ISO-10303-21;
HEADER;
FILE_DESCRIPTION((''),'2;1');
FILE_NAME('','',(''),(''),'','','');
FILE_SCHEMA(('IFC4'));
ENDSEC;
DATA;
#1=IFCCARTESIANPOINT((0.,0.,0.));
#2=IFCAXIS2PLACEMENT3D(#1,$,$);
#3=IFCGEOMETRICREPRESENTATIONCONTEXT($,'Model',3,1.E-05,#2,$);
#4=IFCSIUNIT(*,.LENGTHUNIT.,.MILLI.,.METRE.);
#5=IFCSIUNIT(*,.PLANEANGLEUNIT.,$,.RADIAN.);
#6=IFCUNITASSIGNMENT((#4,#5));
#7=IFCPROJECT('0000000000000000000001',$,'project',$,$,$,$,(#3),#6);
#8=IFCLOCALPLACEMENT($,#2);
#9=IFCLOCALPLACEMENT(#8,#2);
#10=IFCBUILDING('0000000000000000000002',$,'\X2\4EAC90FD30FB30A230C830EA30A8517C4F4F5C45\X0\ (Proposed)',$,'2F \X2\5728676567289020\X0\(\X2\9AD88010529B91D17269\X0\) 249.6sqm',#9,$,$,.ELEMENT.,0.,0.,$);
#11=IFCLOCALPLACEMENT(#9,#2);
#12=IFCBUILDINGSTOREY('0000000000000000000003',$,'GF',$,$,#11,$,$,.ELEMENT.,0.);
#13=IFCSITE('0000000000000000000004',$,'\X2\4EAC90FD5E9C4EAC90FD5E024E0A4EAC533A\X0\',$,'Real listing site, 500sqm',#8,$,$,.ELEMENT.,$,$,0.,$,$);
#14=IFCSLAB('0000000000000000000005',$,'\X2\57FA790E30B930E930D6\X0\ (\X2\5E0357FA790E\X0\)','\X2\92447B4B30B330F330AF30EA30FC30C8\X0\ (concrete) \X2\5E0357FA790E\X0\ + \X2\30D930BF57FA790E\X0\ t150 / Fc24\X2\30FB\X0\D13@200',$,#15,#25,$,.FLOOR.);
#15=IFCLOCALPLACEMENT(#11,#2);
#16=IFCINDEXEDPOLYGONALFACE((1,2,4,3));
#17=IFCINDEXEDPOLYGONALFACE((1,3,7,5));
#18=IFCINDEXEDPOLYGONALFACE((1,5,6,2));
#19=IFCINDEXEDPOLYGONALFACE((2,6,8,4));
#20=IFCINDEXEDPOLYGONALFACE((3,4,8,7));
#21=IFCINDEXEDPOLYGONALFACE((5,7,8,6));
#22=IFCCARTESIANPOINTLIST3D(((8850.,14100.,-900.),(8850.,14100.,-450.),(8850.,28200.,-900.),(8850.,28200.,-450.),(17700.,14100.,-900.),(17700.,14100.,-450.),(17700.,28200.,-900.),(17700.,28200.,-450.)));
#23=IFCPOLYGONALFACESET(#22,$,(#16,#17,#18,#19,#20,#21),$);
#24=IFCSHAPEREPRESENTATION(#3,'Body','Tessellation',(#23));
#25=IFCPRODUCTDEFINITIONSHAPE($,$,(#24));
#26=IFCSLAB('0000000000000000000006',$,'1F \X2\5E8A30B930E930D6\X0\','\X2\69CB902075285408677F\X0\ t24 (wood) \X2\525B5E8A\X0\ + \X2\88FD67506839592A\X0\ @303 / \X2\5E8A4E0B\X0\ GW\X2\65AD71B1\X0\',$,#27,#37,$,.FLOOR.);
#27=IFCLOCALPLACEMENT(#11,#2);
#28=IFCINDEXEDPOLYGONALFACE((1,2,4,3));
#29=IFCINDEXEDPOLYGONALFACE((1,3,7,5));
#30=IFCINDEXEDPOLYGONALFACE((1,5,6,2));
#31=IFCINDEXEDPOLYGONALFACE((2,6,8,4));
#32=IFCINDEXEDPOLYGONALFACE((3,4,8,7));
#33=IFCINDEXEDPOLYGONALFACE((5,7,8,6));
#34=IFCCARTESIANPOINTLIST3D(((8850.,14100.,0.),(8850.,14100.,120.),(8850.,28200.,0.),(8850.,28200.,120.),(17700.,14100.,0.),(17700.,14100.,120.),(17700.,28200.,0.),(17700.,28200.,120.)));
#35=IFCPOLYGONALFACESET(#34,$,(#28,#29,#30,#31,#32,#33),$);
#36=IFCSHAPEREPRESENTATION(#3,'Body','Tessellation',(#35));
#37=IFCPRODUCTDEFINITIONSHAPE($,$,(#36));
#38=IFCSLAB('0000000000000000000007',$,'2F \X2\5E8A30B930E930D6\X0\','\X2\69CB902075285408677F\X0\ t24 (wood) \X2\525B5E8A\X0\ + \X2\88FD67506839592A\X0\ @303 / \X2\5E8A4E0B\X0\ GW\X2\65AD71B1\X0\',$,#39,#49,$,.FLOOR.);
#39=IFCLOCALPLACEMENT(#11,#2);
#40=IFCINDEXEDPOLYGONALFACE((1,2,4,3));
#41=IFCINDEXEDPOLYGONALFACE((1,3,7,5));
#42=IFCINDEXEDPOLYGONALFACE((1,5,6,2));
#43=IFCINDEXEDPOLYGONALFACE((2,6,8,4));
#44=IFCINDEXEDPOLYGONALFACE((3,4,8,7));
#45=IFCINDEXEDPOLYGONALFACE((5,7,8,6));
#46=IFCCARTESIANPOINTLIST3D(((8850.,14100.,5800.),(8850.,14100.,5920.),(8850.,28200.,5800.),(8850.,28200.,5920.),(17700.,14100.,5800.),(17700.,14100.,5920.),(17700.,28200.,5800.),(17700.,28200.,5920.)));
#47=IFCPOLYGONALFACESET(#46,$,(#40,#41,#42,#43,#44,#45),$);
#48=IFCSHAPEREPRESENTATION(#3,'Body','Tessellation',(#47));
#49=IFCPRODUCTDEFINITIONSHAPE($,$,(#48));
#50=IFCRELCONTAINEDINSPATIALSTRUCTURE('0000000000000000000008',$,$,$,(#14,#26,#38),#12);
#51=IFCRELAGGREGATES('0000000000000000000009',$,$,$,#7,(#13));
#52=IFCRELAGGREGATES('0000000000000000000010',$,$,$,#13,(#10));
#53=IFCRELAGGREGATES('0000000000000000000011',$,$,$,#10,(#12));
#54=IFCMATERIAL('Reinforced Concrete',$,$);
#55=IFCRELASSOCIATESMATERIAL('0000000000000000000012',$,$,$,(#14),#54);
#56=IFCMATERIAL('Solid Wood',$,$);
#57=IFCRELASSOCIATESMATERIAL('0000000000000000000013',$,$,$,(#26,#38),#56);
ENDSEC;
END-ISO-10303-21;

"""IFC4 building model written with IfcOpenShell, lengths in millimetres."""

from ifc_helpers import new_model, si_unit, frame, frame_2d, origin, place, context, project, spatial, rectangle, extrude, material, element, save


model = new_model("IFC4")

# Units and contexts
model_context = context("Model", 3, precision=1e-05, world=origin())
ifc_project = project(units=[si_unit("LENGTHUNIT", "METRE", prefix="MILLI"), si_unit("PLANEANGLEUNIT", "RADIAN")], contexts=[model_context])

# Site, building, storey
site_placement = place(None, origin())
site = spatial("IfcSite", under=ifc_project, at=site_placement, Name="京都府京都市上京区", ObjectType="Real listing site, 500sqm", CompositionType="ELEMENT", RefElevation=0.0)
building_placement = place(site_placement, origin())
building = spatial("IfcBuilding", under=site, at=building_placement, Name="京都・アトリエ兼住居 (Proposed)", ObjectType="2F 在来木造(高耐力金物) 249.6sqm", CompositionType="ELEMENT", ElevationOfRefHeight=0.0, ElevationOfTerrain=0.0)
storey_placement = place(building_placement, origin())
storey = spatial("IfcBuildingStorey", under=building, at=storey_placement, Name="GF", CompositionType="ELEMENT", Elevation=0.0)

# Shared definitions
ifc_material_1 = material(Name="Solid Wood")

# Slabs
ifc_material_2 = material(Name="Reinforced Concrete")
slab_1_placement = place(storey_placement, frame((4425.0, 7050.0, -450.0)))
element("IfcSlab", 1, at=slab_1_placement, inside=storey, material=ifc_material_2, Name="基礎スラブ (布基礎)", Description="鉄筋コンクリート (concrete) 布基礎 + ベタ基礎 t150 / Fc24・D13@200", PredefinedType="FLOOR", context=model_context, shape_type="SweptSolid", body=[
    extrude(rectangle(XDim=8850.0, YDim=14100.0, at=frame_2d((4425.0, 7050.0))), frame((4425.0, 7050.0, -450.0)), (0.0, 0.0, 1.0), 450.0),
])
slab_2_placement = place(storey_placement, frame((4425.0, 7050.0, 0.0)))
element("IfcSlab", 2, at=slab_2_placement, inside=storey, material=ifc_material_1, Name="1F 床スラブ", Description="構造用合板 t24 (wood) 剛床 + 製材根太 @303 / 床下 GW断熱", PredefinedType="FLOOR", context=model_context, shape_type="SweptSolid", body=[
    extrude(rectangle(XDim=8850.0, YDim=14100.0, at=frame_2d((4425.0, 7050.0))), frame((4425.0, 7050.0, 0.0)), (0.0, 0.0, 1.0), 120.0),
])
slab_3_placement = place(storey_placement, frame((4425.0, 7050.0, 2900.0)))
element("IfcSlab", 3, at=slab_3_placement, inside=storey, material=ifc_material_1, Name="2F 床スラブ", Description="構造用合板 t24 (wood) 剛床 + 製材根太 @303 / 床下 GW断熱", PredefinedType="FLOOR", context=model_context, shape_type="SweptSolid", body=[
    extrude(rectangle(XDim=8850.0, YDim=14100.0, at=frame_2d((4425.0, 7050.0))), frame((4425.0, 7050.0, 2900.0)), (0.0, 0.0, 1.0), 120.0),
])

save(model, "model.ifc")
